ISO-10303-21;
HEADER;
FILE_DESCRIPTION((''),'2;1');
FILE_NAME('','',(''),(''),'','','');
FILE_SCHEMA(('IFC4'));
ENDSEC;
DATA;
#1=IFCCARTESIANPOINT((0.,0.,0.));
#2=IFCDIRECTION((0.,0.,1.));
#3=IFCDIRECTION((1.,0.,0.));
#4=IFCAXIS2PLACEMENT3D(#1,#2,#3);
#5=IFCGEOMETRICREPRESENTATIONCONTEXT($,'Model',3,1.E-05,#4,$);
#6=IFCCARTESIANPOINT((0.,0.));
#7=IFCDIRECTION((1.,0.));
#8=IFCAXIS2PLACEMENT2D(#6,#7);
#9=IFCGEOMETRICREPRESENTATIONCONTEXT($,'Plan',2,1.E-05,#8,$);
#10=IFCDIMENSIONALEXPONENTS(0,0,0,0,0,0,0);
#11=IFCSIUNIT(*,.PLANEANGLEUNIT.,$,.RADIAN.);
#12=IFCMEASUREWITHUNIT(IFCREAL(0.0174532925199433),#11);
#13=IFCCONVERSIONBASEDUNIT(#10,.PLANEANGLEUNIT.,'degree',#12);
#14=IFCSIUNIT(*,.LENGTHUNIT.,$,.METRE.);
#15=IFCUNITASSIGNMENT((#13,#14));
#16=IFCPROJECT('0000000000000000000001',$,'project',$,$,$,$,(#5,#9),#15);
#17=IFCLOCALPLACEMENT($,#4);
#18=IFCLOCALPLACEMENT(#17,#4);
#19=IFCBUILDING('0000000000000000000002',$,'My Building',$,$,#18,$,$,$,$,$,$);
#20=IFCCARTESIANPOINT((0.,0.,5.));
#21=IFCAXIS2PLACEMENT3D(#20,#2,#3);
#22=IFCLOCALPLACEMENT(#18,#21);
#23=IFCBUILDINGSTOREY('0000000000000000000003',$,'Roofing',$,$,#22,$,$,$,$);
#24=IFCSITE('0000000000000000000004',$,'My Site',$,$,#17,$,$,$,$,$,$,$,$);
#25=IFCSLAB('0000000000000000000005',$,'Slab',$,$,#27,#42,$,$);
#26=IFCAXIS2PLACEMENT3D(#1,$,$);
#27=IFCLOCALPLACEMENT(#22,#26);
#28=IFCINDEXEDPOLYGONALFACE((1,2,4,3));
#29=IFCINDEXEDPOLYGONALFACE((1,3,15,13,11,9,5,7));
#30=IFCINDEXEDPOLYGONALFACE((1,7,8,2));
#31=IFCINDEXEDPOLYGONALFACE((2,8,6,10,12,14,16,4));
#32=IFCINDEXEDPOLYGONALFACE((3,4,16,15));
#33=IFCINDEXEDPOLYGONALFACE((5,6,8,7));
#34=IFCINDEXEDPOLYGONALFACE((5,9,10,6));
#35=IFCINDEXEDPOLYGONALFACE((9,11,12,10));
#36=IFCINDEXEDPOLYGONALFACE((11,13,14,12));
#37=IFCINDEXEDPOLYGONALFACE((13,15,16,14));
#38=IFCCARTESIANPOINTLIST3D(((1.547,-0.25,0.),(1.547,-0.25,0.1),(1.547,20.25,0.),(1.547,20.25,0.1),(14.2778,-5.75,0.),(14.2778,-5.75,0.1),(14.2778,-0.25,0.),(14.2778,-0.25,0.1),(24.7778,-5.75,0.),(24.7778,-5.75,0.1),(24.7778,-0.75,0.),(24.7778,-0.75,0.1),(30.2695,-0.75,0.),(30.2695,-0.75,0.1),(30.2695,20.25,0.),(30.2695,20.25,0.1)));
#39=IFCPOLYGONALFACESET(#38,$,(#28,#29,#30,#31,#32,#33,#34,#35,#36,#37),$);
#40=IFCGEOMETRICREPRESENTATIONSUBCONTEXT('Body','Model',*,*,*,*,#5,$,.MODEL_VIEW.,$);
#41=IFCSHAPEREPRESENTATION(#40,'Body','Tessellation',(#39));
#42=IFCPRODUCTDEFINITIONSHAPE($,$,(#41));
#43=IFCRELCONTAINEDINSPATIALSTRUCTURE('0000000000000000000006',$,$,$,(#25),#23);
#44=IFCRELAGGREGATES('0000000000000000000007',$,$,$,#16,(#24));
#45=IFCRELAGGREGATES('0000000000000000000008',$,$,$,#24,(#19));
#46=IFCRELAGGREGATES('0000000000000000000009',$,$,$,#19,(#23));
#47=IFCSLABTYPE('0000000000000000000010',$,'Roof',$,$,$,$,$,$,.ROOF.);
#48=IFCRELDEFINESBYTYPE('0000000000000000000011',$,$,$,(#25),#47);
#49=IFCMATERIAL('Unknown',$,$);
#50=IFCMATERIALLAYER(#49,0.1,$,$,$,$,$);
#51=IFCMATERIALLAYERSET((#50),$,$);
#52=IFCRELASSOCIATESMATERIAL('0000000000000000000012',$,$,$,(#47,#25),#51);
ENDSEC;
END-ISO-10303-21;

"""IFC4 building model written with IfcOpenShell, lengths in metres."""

from ifc_helpers import new_model, entity, si_unit, converted_unit, frame, origin_with_axes, origin_2d_with_axis, place, context, subcontext, project, spatial, indexed_curve, outline, extrude, material, layer, layer_set, layer_usage, type_object, element, save


model = new_model("IFC4")

# Units and contexts
model_context = context("Model", 3, precision=1e-05, world=origin_with_axes())
plan_context = context("Plan", 2, precision=1e-05, world=origin_2d_with_axis())
body_context = subcontext(model_context, "Body", "Model", "MODEL_VIEW")
ifc_project = project(units=[converted_unit("PLANEANGLEUNIT", "degree", entity("IfcReal", 0.0174532925199433), si_unit("PLANEANGLEUNIT", "RADIAN"), dimensions=[0, 0, 0, 0, 0, 0, 0]), si_unit("LENGTHUNIT", "METRE")], contexts=[model_context, plan_context])

# Site, building, storey
site_placement = place(None, origin_with_axes())
site = spatial("IfcSite", under=ifc_project, at=site_placement, Name="My Site")
building_placement = place(site_placement, origin_with_axes())
building = spatial("IfcBuilding", under=site, at=building_placement, Name="My Building")
storey_placement = place(building_placement, frame((0.0, 0.0, 5.0), z_axis=(0.0, 0.0, 1.0), x_axis=(1.0, 0.0, 0.0)))
storey = spatial("IfcBuildingStorey", under=building, at=storey_placement, Name="Roofing")

# Slab
ifc_material = material(Name="Unknown")
ifc_layer = layer(ifc_material, 0.1)
ifc_layer_set = layer_set([ifc_layer])
ifc_layer_usage = layer_usage(ifc_layer_set, "AXIS3", "POSITIVE", -0.1)
slab_type = type_object("IfcSlabType", Name="Roof", PredefinedType="ROOF", material=ifc_layer_set)
slab_placement = place(storey_placement, frame((1.547, 20.25, 0.1), z_axis=(0.0, 0.0, 1.0), x_axis=(1.0, 0.0, 0.0)))
element("IfcSlab", 1, at=slab_placement, inside=storey, type_object=slab_type, material=ifc_layer_usage, Name="Slab", context=body_context, shape_type="SweptSolid", body=[
    extrude(outline(indexed_curve([(0.0, 0.0), (0.0, -20.5), (12.7308, -20.5), (12.7308, -26.0), (23.2308, -26.0), (23.2308, -21.0), (28.7225, -21.0), (28.7225, 0.0), (0.0, 0.0)])), frame((0.0, 0.0, -0.1), z_axis=(0.0, 0.0, 1.0), x_axis=(1.0, 0.0, 0.0)), (0.0, 0.0, 1.0), 0.1),
])

save(model, "model.ifc")
